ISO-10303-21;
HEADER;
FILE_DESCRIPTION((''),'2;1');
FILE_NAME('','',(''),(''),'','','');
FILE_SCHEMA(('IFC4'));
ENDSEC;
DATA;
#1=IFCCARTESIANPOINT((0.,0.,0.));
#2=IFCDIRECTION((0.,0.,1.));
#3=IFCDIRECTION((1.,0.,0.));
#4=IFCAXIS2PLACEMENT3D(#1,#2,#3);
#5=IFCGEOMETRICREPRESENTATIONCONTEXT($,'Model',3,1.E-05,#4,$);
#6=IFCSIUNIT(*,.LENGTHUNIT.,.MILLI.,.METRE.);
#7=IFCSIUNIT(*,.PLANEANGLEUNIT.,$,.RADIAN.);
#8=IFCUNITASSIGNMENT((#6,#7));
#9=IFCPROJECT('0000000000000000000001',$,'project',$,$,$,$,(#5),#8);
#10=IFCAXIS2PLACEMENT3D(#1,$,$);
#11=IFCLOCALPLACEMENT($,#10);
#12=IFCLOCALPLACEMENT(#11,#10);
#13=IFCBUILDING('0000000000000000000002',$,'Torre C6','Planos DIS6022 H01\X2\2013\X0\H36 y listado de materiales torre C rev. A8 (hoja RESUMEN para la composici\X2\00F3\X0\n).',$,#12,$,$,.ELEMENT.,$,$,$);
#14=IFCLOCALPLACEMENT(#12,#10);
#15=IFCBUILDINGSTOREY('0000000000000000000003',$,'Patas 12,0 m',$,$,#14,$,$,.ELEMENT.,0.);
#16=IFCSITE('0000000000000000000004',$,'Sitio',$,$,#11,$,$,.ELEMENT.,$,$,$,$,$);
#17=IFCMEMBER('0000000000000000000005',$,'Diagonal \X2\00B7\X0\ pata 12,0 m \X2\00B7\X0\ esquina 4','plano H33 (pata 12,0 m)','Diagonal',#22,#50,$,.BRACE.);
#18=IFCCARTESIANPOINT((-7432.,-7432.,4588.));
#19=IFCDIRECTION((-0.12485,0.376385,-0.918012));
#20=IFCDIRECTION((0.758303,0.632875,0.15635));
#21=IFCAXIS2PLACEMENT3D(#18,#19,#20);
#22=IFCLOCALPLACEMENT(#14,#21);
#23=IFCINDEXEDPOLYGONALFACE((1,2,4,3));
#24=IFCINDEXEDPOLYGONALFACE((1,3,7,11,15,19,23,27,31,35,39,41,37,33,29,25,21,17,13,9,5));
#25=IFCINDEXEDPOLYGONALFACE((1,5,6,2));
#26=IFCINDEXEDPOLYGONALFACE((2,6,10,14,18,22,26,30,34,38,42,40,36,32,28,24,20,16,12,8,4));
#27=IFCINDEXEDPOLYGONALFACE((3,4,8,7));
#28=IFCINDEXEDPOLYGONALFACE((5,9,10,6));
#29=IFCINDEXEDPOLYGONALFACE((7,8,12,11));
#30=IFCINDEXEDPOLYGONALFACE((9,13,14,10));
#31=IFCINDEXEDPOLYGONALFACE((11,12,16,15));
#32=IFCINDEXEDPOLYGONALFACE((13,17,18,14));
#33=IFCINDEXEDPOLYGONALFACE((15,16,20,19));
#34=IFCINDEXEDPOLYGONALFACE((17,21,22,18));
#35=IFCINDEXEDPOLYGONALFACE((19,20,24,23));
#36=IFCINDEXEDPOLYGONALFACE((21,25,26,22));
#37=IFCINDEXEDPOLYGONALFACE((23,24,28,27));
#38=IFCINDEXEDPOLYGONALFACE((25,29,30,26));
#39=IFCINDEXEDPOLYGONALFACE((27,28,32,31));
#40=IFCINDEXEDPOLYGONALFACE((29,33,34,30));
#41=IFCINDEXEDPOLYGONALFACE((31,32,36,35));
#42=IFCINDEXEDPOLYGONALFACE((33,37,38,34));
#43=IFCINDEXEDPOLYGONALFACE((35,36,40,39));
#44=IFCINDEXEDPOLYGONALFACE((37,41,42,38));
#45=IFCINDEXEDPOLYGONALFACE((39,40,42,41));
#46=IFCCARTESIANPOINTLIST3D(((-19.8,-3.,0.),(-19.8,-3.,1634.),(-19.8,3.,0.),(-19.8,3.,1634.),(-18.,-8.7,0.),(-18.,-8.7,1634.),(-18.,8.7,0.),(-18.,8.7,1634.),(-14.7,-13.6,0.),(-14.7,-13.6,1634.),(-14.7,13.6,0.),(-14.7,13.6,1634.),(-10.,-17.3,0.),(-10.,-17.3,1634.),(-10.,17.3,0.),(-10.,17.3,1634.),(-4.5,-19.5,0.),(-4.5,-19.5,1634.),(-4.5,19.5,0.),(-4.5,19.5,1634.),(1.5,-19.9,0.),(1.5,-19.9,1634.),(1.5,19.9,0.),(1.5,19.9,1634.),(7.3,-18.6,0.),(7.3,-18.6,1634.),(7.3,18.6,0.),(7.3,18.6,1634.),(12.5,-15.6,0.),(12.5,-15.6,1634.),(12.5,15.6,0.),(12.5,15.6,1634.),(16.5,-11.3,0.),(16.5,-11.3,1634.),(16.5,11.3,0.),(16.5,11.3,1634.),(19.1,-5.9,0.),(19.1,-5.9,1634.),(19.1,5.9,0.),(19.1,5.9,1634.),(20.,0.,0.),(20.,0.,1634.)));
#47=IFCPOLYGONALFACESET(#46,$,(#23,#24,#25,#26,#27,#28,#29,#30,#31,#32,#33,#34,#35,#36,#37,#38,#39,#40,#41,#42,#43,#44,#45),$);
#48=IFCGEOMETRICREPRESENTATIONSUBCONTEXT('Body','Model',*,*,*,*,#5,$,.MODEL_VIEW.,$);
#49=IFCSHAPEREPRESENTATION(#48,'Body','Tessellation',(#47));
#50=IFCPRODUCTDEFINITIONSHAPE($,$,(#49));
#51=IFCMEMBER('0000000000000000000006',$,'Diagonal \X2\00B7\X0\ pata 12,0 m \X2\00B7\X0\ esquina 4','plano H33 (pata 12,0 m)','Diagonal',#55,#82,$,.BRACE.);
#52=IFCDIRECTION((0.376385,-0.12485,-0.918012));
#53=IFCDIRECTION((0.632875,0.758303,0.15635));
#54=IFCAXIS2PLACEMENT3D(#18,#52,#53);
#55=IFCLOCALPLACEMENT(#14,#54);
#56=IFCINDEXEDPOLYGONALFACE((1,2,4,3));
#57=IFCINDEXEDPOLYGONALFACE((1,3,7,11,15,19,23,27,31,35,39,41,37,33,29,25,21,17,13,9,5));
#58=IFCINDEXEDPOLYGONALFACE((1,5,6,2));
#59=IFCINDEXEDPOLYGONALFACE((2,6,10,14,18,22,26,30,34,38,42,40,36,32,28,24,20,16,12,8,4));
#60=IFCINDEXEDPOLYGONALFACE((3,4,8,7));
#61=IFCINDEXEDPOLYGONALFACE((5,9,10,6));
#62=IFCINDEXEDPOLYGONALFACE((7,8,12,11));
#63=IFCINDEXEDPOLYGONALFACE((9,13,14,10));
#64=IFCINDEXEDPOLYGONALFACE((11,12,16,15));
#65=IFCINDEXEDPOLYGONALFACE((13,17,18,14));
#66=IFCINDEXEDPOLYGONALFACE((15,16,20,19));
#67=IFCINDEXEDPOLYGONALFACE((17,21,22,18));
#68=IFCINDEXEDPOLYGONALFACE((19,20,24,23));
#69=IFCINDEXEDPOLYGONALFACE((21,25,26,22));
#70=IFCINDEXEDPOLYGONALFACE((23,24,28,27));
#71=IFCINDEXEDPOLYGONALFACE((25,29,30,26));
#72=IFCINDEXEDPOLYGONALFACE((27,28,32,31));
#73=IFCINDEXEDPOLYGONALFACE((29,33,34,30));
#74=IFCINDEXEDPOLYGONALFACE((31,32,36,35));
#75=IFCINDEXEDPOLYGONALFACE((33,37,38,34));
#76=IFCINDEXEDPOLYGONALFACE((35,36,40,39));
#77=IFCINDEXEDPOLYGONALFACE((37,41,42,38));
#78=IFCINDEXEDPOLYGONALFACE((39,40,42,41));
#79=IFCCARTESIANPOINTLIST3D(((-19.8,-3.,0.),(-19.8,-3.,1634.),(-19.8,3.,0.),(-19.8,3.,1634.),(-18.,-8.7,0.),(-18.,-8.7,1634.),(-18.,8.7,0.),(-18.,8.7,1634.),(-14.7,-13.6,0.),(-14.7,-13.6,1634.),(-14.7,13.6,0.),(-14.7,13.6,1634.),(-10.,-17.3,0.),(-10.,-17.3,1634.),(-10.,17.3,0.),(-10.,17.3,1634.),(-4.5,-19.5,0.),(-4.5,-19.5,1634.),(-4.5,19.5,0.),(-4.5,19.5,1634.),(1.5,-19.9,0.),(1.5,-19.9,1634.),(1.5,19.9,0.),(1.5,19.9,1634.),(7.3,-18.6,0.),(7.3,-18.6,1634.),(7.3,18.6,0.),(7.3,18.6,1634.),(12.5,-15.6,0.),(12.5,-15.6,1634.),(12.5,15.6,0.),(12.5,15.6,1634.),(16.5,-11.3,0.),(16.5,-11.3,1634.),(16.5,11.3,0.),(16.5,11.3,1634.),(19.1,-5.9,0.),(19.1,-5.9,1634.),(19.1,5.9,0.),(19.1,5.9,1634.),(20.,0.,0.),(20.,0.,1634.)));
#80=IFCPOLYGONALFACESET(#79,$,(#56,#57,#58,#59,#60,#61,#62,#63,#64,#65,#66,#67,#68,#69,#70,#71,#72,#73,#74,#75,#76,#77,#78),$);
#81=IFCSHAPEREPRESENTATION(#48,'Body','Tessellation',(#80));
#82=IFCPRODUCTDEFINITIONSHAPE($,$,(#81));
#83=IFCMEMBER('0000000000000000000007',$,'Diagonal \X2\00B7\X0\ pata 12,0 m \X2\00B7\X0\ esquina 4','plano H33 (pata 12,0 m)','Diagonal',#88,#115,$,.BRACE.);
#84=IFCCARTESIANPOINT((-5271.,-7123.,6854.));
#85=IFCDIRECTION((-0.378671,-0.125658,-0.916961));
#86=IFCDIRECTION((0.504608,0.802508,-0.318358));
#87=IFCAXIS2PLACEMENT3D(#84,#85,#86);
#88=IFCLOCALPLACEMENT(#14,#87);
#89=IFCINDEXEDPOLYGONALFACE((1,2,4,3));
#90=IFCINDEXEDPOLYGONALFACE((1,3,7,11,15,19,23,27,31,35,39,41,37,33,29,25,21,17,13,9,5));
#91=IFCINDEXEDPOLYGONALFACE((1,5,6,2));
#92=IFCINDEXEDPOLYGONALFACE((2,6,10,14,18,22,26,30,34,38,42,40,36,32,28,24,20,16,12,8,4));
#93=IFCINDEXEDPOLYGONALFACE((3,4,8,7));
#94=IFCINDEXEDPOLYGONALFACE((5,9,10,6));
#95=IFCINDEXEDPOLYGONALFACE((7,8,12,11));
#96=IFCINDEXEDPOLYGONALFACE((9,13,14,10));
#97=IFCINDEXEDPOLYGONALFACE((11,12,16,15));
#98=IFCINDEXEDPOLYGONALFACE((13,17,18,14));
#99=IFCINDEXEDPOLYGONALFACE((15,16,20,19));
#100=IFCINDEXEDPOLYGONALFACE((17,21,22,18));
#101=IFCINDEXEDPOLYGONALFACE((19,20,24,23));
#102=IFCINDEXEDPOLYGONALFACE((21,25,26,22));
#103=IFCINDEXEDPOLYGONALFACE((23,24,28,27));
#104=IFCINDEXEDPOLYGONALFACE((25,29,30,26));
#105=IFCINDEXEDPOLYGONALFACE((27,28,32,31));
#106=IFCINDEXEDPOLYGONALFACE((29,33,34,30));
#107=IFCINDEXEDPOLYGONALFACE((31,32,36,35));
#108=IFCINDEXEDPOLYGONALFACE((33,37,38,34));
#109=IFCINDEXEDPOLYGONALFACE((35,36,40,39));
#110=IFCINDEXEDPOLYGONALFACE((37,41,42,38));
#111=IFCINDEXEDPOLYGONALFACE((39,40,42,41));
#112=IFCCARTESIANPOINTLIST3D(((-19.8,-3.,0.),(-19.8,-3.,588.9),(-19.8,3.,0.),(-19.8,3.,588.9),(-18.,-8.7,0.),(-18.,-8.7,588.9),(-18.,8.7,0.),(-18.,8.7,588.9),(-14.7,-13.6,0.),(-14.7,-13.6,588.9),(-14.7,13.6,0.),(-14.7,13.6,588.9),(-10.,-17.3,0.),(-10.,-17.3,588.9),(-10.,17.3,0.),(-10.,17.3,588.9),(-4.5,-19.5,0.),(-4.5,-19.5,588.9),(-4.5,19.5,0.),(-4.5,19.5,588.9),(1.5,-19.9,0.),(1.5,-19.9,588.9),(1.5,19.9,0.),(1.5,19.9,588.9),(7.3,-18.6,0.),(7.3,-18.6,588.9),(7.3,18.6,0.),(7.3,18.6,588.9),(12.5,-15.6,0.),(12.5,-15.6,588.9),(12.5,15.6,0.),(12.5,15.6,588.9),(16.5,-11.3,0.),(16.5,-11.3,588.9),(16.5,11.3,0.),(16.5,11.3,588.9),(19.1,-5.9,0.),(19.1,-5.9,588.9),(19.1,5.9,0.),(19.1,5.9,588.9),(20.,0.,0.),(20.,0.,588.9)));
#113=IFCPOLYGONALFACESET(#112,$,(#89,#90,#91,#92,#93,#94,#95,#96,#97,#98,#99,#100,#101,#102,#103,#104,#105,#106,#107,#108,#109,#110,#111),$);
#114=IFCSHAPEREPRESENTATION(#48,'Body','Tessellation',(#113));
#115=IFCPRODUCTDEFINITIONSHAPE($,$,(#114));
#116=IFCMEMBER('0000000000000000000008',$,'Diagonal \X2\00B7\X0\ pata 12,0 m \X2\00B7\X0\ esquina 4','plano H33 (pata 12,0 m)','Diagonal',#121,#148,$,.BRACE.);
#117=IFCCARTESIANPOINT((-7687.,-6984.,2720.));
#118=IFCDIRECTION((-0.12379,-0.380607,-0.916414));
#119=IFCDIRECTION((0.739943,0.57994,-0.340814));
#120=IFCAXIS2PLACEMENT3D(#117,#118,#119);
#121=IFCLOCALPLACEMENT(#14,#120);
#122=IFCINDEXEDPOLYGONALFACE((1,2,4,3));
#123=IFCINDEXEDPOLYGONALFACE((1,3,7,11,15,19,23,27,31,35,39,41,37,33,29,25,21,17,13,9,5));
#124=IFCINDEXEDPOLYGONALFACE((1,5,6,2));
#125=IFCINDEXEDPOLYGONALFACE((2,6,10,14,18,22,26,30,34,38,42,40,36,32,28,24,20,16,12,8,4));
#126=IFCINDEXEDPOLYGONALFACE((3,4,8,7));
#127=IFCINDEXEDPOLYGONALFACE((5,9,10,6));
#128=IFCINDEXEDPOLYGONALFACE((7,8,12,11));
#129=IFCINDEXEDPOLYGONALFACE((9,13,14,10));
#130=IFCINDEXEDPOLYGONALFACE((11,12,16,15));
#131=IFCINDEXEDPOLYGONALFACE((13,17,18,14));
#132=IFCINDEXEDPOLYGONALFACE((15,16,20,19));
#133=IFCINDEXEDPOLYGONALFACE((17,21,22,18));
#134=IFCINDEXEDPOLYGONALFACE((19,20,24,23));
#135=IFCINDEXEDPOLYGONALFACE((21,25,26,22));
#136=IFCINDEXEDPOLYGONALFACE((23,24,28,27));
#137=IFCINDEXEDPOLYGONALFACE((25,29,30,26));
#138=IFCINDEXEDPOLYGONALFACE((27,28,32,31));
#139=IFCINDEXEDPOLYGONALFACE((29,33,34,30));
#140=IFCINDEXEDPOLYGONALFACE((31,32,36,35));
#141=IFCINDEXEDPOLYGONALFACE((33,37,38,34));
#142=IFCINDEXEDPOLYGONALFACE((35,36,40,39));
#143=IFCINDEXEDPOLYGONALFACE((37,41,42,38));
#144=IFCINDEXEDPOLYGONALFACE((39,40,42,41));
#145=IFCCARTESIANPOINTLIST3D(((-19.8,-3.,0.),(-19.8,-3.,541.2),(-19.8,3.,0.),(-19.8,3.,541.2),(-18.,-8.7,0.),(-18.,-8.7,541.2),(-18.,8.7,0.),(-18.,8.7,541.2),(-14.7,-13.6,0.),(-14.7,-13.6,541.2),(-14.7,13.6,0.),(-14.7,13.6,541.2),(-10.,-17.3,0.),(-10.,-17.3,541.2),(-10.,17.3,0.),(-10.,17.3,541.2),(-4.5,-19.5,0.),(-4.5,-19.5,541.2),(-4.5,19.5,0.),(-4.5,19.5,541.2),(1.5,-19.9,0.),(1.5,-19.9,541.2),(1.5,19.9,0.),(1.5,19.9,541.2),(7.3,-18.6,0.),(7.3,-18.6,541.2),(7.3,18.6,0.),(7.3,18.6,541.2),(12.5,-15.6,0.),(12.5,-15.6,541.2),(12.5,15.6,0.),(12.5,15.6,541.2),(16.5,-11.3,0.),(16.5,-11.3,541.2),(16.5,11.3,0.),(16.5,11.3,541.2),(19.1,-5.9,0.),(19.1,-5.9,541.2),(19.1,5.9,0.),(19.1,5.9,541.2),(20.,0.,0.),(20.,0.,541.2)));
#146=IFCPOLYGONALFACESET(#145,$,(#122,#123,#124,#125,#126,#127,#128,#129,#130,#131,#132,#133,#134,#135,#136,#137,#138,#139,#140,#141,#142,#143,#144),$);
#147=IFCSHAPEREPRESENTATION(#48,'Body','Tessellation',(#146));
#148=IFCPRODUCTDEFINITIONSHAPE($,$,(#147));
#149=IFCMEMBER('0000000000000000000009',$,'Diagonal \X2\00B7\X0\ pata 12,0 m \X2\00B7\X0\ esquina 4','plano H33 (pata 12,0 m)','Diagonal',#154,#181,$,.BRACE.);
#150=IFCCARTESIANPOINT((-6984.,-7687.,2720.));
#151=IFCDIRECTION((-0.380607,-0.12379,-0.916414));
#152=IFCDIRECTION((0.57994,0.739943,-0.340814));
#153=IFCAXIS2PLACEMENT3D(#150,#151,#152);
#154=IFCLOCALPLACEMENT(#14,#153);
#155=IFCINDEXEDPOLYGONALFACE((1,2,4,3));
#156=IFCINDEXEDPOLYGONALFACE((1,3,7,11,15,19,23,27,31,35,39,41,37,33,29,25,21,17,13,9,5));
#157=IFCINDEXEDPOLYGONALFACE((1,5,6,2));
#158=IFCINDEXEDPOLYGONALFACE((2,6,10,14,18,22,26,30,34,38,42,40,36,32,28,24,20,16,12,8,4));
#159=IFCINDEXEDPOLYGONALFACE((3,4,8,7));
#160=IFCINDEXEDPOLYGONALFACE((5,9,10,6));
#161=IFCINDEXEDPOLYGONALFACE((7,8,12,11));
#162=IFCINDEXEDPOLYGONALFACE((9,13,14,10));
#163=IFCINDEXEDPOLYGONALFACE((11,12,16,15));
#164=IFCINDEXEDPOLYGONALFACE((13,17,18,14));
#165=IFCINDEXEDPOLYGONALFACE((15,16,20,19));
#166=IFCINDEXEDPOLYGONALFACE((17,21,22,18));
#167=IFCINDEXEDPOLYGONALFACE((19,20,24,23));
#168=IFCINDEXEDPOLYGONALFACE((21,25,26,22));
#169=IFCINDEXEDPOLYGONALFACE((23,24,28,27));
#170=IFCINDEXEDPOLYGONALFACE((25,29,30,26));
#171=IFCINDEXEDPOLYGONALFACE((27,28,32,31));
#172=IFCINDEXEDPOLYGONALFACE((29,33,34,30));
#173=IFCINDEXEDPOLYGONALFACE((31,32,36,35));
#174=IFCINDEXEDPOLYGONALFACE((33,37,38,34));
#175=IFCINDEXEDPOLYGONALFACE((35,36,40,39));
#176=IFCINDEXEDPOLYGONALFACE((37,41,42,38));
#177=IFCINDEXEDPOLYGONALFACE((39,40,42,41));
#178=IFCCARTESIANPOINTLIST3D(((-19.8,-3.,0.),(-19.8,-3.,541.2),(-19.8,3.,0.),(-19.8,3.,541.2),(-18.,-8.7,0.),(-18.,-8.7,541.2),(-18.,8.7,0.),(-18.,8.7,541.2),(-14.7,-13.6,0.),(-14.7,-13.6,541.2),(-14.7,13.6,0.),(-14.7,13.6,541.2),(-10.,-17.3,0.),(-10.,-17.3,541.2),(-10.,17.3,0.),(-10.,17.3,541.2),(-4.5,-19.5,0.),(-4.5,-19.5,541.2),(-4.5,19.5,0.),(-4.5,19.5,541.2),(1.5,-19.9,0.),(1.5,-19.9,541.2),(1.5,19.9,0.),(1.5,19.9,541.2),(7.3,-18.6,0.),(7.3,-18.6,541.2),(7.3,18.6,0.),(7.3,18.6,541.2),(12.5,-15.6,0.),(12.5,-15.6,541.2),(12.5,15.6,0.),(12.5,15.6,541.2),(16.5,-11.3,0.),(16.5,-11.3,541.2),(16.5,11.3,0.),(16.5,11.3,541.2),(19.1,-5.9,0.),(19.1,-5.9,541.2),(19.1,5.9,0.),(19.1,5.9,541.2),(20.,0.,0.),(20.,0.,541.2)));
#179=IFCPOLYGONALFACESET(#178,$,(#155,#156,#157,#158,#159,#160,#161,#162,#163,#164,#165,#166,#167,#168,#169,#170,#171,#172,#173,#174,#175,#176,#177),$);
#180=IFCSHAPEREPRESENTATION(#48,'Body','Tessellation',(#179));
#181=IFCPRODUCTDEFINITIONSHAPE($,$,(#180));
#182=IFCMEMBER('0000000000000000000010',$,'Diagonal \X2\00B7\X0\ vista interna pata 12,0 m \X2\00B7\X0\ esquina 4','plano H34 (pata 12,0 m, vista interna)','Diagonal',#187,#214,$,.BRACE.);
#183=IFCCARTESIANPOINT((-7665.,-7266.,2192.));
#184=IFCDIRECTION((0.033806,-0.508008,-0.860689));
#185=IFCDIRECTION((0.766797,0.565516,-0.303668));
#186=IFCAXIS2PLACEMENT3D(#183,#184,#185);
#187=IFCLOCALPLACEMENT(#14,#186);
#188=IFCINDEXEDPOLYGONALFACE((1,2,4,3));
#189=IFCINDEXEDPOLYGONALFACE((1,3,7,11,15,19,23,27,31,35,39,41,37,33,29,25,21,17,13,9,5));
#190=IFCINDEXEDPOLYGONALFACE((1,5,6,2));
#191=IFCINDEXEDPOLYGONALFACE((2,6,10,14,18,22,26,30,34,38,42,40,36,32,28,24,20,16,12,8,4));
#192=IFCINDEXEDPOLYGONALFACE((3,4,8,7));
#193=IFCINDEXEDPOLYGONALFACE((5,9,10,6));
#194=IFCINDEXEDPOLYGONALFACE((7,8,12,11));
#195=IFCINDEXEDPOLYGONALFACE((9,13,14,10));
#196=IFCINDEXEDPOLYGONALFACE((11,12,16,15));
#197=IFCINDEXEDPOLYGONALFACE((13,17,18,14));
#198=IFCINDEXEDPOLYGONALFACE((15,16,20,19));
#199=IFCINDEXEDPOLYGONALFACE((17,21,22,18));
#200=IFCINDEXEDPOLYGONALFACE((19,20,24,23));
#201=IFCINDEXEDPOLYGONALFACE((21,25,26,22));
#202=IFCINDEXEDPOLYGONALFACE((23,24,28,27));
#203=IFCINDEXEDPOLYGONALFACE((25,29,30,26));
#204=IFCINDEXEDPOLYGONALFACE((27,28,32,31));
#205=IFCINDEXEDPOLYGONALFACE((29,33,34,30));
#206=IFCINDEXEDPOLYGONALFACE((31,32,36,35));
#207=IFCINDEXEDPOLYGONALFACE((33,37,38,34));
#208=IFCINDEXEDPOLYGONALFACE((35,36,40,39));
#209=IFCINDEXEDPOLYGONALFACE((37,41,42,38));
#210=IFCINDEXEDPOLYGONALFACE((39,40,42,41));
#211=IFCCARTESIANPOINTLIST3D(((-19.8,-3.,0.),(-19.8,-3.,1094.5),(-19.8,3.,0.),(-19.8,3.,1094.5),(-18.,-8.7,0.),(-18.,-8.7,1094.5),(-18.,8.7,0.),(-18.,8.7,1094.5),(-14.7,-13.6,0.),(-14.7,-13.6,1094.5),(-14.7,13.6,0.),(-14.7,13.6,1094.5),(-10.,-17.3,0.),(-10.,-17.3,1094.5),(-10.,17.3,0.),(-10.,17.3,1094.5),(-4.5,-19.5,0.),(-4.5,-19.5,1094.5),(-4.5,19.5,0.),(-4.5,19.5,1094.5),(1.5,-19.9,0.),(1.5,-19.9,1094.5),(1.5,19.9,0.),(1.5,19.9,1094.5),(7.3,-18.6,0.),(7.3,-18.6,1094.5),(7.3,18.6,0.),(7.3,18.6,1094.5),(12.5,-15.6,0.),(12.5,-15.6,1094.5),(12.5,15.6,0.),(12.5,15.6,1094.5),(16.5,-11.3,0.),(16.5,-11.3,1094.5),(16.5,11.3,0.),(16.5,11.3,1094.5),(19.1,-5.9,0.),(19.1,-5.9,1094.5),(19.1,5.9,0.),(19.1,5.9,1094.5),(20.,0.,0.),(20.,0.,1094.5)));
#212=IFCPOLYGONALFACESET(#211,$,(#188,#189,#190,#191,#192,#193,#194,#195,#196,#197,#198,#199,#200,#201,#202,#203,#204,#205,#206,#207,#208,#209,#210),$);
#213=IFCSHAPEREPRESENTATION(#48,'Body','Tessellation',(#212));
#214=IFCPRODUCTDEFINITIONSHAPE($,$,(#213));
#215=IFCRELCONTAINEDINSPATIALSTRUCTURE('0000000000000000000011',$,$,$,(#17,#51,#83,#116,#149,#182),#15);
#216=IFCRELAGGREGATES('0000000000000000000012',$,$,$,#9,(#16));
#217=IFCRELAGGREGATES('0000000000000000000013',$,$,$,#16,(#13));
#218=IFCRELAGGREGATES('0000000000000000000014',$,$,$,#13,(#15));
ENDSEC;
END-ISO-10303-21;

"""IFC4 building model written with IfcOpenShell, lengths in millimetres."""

from ifc_helpers import new_model, si_unit, frame, origin, origin_with_axes, place, context, subcontext, project, spatial, circle, extrude, element, save


model = new_model("IFC4")

# Units and contexts
model_context = context("Model", 3, precision=1e-05, world=origin_with_axes())
body_context = subcontext(model_context, "Body", "Model", "MODEL_VIEW")
ifc_project = project(units=[si_unit("LENGTHUNIT", "METRE", prefix="MILLI"), si_unit("PLANEANGLEUNIT", "RADIAN")], contexts=[model_context])

# Site, building, storey
site_placement = place(None, origin())
site = spatial("IfcSite", under=ifc_project, at=site_placement, Name="Sitio", CompositionType="ELEMENT")
building_placement = place(site_placement, origin())
building = spatial("IfcBuilding", under=site, at=building_placement, Name="Torre C6", Description="Planos DIS6022 H01–H36 y listado de materiales torre C rev. A8 (hoja RESUMEN para la composición).", CompositionType="ELEMENT")
storey_placement = place(building_placement, origin())
storey = spatial("IfcBuildingStorey", under=building, at=storey_placement, Name="Patas 12,0 m", CompositionType="ELEMENT", Elevation=0.0)

# Members
for number, where, z_axis, x_axis, name in (
    (1, (-7432.0, -7432.0, 4588.0), (-0.12485, 0.376385, -0.918012), (0.758303, 0.632875, 0.15635), "Diagonal · pata 12,0 m · esquina 4"),
    (2, (-7432.0, -7432.0, 4588.0), (0.376385, -0.12485, -0.918012), (0.632875, 0.758303, 0.15635), "Diagonal · pata 12,0 m · esquina 4"),
):
    element("IfcMember", number, at=place(storey_placement, frame(where, z_axis=z_axis, x_axis=x_axis)), inside=storey, Name=name, Description="plano H33 (pata 12,0 m)", ObjectType="Diagonal", PredefinedType="BRACE", context=body_context, shape_type="SweptSolid", body=[
        extrude(circle(Radius=20.0), None, (0.0, 0.0, 1.0), 1634.0),
    ])
member_1_placement = place(storey_placement, frame((-5271.0, -7123.0, 6854.0), z_axis=(-0.378671, -0.125658, -0.916961), x_axis=(0.504608, 0.802508, -0.318358)))
element("IfcMember", 3, at=member_1_placement, inside=storey, Name="Diagonal · pata 12,0 m · esquina 4", Description="plano H33 (pata 12,0 m)", ObjectType="Diagonal", PredefinedType="BRACE", context=body_context, shape_type="SweptSolid", body=[
    extrude(circle(Radius=20.0), None, (0.0, 0.0, 1.0), 588.9),
])
for number, where, z_axis, x_axis, name in (
    (4, (-7687.0, -6984.0, 2720.0), (-0.12379, -0.380607, -0.916414), (0.739943, 0.57994, -0.340814), "Diagonal · pata 12,0 m · esquina 4"),
    (5, (-6984.0, -7687.0, 2720.0), (-0.380607, -0.12379, -0.916414), (0.57994, 0.739943, -0.340814), "Diagonal · pata 12,0 m · esquina 4"),
):
    element("IfcMember", number, at=place(storey_placement, frame(where, z_axis=z_axis, x_axis=x_axis)), inside=storey, Name=name, Description="plano H33 (pata 12,0 m)", ObjectType="Diagonal", PredefinedType="BRACE", context=body_context, shape_type="SweptSolid", body=[
        extrude(circle(Radius=20.0), None, (0.0, 0.0, 1.0), 541.2),
    ])
member_2_placement = place(storey_placement, frame((-7665.0, -7266.0, 2192.0), z_axis=(0.033806, -0.508008, -0.860689), x_axis=(0.766797, 0.565516, -0.303668)))
element("IfcMember", 6, at=member_2_placement, inside=storey, Name="Diagonal · vista interna pata 12,0 m · esquina 4", Description="plano H34 (pata 12,0 m, vista interna)", ObjectType="Diagonal", PredefinedType="BRACE", context=body_context, shape_type="SweptSolid", body=[
    extrude(circle(Radius=20.0), None, (0.0, 0.0, 1.0), 1094.5),
])

save(model, "model.ifc")
